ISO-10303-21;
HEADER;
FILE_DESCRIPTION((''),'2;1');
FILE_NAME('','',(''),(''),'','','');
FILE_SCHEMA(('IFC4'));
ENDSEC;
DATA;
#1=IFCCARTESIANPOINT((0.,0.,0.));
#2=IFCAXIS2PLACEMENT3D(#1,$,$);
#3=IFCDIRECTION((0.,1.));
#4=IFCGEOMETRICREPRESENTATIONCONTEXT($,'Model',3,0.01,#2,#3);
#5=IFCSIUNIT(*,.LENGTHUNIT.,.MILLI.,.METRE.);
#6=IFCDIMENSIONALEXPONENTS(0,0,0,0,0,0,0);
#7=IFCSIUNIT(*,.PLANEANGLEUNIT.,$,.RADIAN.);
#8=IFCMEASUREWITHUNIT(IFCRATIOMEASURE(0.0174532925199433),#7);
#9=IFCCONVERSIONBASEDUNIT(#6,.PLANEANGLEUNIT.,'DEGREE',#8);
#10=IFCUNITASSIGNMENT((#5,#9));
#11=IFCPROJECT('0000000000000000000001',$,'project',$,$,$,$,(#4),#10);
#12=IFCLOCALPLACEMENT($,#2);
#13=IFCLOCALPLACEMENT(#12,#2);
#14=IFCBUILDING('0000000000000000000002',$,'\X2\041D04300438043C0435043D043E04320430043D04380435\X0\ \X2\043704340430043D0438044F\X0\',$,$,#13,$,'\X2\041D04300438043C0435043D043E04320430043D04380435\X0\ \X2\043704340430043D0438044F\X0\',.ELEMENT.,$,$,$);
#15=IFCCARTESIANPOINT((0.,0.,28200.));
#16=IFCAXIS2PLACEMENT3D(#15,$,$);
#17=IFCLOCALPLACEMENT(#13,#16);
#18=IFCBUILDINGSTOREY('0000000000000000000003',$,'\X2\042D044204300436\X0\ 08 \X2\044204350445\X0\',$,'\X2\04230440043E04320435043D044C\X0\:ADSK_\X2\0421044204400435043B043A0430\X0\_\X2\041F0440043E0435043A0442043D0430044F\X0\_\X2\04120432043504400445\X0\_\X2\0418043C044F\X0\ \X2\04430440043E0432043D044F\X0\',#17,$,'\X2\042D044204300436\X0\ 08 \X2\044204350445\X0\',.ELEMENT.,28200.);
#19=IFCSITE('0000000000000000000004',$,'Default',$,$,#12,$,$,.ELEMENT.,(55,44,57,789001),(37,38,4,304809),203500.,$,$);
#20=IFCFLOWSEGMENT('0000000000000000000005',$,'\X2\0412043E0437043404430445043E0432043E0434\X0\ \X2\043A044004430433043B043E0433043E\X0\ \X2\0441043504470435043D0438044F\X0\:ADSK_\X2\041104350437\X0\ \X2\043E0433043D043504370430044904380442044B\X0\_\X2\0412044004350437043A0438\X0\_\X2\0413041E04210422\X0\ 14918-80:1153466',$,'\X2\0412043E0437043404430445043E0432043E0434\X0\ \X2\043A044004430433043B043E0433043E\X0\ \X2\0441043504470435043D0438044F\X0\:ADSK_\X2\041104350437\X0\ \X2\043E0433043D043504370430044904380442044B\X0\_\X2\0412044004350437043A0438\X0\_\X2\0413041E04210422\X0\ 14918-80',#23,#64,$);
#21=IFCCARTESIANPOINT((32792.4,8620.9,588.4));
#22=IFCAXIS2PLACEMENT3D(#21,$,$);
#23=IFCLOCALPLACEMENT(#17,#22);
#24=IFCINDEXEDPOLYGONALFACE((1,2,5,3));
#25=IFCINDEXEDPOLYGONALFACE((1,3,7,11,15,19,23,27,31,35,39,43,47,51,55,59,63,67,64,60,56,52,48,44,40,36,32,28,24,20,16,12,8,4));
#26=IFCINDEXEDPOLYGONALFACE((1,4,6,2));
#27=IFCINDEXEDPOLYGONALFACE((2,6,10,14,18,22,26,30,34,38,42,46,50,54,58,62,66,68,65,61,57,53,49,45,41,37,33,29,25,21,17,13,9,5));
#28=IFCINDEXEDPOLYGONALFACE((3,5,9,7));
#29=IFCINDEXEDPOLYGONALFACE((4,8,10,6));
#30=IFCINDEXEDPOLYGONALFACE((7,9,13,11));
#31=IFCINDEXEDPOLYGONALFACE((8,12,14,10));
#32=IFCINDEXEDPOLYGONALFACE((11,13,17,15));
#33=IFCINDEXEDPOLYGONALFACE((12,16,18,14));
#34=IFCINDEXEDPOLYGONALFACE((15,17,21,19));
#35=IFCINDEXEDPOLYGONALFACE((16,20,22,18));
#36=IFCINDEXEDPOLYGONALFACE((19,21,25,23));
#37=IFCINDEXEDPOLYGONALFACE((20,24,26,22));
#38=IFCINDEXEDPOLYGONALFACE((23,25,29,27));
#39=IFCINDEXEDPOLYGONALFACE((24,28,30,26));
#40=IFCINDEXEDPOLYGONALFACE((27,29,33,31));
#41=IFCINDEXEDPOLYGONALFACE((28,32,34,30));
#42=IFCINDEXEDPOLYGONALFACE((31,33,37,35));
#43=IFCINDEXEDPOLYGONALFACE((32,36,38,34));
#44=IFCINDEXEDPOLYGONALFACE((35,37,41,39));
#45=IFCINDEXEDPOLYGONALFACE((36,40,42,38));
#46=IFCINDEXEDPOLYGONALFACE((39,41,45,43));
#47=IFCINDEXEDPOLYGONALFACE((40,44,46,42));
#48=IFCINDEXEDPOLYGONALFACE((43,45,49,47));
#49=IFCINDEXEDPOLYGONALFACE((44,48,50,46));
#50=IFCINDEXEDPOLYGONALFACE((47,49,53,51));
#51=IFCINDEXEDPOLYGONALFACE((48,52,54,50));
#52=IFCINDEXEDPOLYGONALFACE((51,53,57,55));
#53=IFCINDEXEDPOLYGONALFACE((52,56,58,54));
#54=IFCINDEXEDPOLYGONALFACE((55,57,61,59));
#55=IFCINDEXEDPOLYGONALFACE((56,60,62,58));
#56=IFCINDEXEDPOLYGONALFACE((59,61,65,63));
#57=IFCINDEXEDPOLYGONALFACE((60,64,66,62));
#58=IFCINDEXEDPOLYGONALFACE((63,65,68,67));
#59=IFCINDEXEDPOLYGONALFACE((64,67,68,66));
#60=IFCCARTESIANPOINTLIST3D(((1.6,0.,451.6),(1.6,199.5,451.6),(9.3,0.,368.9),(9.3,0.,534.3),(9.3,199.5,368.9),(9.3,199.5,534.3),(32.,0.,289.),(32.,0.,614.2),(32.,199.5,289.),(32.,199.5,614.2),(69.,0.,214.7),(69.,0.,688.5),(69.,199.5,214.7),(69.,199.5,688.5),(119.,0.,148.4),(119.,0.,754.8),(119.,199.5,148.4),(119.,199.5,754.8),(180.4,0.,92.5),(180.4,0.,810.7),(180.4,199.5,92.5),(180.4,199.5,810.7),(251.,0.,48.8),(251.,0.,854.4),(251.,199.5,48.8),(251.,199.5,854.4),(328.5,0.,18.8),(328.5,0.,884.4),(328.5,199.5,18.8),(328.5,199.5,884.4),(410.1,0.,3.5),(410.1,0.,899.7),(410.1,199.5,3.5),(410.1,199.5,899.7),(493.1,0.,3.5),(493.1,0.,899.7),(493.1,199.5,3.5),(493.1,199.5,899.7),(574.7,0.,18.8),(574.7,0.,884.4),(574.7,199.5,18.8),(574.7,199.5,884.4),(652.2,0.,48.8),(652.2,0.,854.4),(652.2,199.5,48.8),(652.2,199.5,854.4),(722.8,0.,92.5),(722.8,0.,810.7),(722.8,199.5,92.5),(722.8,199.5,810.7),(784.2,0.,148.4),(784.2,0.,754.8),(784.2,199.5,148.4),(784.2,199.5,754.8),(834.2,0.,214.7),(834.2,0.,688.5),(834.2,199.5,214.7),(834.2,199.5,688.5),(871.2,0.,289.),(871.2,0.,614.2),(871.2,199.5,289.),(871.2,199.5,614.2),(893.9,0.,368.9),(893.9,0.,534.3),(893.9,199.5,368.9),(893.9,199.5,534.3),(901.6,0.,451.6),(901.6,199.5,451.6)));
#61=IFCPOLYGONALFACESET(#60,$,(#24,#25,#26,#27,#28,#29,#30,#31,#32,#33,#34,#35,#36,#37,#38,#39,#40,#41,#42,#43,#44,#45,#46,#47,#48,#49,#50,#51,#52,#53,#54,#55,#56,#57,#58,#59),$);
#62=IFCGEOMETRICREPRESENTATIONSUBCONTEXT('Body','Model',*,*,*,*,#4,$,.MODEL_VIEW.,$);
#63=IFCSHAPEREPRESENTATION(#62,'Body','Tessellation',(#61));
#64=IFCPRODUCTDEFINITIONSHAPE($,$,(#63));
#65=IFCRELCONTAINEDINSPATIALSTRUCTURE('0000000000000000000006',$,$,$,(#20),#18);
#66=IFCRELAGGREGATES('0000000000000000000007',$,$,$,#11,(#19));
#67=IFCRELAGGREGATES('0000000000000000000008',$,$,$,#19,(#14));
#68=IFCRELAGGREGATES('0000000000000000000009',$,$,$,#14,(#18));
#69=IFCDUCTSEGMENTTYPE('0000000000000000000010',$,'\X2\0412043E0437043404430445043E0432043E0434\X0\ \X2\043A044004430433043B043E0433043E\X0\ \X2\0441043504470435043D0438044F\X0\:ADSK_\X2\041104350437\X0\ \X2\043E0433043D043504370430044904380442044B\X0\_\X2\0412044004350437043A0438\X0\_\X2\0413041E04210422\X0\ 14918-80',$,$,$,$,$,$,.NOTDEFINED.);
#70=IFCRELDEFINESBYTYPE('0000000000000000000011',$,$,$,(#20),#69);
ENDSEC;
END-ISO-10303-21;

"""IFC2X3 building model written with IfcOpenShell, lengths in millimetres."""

from ifc_helpers import new_model, entity, si_unit, converted_unit, direction, frame, origin, origin_2d_with_axis, place, context, subcontext, project, spatial, circle, extrude, type_object, element, save


model = new_model("IFC2X3")

# Units and contexts
model_context = context("Model", 3, precision=0.01, world=origin(), true_north=direction((0.0, 1.0)))
body_context = subcontext(model_context, "Body", "Model", "MODEL_VIEW")
ifc_project = project(units=[si_unit("LENGTHUNIT", "METRE", prefix="MILLI"), converted_unit("PLANEANGLEUNIT", "DEGREE", entity("IfcRatioMeasure", 0.0174532925199433), si_unit("PLANEANGLEUNIT", "RADIAN"), dimensions=[0, 0, 0, 0, 0, 0, 0])], contexts=[model_context])

# Site, building, storey
site_placement = place(None, origin())
site = spatial("IfcSite", under=ifc_project, at=site_placement, Name="Default", CompositionType="ELEMENT", RefLatitude=(55, 44, 57, 789001), RefLongitude=(37, 38, 4, 304809), RefElevation=203500.0)
building_placement = place(site_placement, origin())
building = spatial("IfcBuilding", under=site, at=building_placement, Name="Наименование здания", LongName="Наименование здания", CompositionType="ELEMENT")
storey_placement = place(building_placement, frame((0.0, 0.0, 28200.0)))
storey = spatial("IfcBuildingStorey", under=building, at=storey_placement, Name="Этаж 08 тех", ObjectType="Уровень:ADSK_Стрелка_Проектная_Вверх_Имя уровня", LongName="Этаж 08 тех", CompositionType="ELEMENT", Elevation=28200.0)

# Flow segment
duct_segment_type_1 = type_object("IfcDuctSegmentType", Name="Воздуховод круглого сечения:ADSK_Без огнезащиты_Врезки_ГОСТ 14918-80", PredefinedType="NOTDEFINED")
flow_segment_1_placement = place(storey_placement, frame((32792.4, 8620.9, 588.4)))
element("IfcFlowSegment", 1, at=flow_segment_1_placement, inside=storey, type_object=duct_segment_type_1, Name="Воздуховод круглого сечения:ADSK_Без огнезащиты_Врезки_ГОСТ 14918-80:1153466", ObjectType="Воздуховод круглого сечения:ADSK_Без огнезащиты_Врезки_ГОСТ 14918-80", context=body_context, shape_type="SweptSolid", body=[
    extrude(circle(Radius=450.0, at=origin_2d_with_axis()), frame((451.6, 0.0, 451.6), z_axis=(0.0, 1.0, 0.0), x_axis=(-1.0, 0.0, 0.0)), (0.0, 0.0, 1.0), 199.5),
])

save(model, "model.ifc")
